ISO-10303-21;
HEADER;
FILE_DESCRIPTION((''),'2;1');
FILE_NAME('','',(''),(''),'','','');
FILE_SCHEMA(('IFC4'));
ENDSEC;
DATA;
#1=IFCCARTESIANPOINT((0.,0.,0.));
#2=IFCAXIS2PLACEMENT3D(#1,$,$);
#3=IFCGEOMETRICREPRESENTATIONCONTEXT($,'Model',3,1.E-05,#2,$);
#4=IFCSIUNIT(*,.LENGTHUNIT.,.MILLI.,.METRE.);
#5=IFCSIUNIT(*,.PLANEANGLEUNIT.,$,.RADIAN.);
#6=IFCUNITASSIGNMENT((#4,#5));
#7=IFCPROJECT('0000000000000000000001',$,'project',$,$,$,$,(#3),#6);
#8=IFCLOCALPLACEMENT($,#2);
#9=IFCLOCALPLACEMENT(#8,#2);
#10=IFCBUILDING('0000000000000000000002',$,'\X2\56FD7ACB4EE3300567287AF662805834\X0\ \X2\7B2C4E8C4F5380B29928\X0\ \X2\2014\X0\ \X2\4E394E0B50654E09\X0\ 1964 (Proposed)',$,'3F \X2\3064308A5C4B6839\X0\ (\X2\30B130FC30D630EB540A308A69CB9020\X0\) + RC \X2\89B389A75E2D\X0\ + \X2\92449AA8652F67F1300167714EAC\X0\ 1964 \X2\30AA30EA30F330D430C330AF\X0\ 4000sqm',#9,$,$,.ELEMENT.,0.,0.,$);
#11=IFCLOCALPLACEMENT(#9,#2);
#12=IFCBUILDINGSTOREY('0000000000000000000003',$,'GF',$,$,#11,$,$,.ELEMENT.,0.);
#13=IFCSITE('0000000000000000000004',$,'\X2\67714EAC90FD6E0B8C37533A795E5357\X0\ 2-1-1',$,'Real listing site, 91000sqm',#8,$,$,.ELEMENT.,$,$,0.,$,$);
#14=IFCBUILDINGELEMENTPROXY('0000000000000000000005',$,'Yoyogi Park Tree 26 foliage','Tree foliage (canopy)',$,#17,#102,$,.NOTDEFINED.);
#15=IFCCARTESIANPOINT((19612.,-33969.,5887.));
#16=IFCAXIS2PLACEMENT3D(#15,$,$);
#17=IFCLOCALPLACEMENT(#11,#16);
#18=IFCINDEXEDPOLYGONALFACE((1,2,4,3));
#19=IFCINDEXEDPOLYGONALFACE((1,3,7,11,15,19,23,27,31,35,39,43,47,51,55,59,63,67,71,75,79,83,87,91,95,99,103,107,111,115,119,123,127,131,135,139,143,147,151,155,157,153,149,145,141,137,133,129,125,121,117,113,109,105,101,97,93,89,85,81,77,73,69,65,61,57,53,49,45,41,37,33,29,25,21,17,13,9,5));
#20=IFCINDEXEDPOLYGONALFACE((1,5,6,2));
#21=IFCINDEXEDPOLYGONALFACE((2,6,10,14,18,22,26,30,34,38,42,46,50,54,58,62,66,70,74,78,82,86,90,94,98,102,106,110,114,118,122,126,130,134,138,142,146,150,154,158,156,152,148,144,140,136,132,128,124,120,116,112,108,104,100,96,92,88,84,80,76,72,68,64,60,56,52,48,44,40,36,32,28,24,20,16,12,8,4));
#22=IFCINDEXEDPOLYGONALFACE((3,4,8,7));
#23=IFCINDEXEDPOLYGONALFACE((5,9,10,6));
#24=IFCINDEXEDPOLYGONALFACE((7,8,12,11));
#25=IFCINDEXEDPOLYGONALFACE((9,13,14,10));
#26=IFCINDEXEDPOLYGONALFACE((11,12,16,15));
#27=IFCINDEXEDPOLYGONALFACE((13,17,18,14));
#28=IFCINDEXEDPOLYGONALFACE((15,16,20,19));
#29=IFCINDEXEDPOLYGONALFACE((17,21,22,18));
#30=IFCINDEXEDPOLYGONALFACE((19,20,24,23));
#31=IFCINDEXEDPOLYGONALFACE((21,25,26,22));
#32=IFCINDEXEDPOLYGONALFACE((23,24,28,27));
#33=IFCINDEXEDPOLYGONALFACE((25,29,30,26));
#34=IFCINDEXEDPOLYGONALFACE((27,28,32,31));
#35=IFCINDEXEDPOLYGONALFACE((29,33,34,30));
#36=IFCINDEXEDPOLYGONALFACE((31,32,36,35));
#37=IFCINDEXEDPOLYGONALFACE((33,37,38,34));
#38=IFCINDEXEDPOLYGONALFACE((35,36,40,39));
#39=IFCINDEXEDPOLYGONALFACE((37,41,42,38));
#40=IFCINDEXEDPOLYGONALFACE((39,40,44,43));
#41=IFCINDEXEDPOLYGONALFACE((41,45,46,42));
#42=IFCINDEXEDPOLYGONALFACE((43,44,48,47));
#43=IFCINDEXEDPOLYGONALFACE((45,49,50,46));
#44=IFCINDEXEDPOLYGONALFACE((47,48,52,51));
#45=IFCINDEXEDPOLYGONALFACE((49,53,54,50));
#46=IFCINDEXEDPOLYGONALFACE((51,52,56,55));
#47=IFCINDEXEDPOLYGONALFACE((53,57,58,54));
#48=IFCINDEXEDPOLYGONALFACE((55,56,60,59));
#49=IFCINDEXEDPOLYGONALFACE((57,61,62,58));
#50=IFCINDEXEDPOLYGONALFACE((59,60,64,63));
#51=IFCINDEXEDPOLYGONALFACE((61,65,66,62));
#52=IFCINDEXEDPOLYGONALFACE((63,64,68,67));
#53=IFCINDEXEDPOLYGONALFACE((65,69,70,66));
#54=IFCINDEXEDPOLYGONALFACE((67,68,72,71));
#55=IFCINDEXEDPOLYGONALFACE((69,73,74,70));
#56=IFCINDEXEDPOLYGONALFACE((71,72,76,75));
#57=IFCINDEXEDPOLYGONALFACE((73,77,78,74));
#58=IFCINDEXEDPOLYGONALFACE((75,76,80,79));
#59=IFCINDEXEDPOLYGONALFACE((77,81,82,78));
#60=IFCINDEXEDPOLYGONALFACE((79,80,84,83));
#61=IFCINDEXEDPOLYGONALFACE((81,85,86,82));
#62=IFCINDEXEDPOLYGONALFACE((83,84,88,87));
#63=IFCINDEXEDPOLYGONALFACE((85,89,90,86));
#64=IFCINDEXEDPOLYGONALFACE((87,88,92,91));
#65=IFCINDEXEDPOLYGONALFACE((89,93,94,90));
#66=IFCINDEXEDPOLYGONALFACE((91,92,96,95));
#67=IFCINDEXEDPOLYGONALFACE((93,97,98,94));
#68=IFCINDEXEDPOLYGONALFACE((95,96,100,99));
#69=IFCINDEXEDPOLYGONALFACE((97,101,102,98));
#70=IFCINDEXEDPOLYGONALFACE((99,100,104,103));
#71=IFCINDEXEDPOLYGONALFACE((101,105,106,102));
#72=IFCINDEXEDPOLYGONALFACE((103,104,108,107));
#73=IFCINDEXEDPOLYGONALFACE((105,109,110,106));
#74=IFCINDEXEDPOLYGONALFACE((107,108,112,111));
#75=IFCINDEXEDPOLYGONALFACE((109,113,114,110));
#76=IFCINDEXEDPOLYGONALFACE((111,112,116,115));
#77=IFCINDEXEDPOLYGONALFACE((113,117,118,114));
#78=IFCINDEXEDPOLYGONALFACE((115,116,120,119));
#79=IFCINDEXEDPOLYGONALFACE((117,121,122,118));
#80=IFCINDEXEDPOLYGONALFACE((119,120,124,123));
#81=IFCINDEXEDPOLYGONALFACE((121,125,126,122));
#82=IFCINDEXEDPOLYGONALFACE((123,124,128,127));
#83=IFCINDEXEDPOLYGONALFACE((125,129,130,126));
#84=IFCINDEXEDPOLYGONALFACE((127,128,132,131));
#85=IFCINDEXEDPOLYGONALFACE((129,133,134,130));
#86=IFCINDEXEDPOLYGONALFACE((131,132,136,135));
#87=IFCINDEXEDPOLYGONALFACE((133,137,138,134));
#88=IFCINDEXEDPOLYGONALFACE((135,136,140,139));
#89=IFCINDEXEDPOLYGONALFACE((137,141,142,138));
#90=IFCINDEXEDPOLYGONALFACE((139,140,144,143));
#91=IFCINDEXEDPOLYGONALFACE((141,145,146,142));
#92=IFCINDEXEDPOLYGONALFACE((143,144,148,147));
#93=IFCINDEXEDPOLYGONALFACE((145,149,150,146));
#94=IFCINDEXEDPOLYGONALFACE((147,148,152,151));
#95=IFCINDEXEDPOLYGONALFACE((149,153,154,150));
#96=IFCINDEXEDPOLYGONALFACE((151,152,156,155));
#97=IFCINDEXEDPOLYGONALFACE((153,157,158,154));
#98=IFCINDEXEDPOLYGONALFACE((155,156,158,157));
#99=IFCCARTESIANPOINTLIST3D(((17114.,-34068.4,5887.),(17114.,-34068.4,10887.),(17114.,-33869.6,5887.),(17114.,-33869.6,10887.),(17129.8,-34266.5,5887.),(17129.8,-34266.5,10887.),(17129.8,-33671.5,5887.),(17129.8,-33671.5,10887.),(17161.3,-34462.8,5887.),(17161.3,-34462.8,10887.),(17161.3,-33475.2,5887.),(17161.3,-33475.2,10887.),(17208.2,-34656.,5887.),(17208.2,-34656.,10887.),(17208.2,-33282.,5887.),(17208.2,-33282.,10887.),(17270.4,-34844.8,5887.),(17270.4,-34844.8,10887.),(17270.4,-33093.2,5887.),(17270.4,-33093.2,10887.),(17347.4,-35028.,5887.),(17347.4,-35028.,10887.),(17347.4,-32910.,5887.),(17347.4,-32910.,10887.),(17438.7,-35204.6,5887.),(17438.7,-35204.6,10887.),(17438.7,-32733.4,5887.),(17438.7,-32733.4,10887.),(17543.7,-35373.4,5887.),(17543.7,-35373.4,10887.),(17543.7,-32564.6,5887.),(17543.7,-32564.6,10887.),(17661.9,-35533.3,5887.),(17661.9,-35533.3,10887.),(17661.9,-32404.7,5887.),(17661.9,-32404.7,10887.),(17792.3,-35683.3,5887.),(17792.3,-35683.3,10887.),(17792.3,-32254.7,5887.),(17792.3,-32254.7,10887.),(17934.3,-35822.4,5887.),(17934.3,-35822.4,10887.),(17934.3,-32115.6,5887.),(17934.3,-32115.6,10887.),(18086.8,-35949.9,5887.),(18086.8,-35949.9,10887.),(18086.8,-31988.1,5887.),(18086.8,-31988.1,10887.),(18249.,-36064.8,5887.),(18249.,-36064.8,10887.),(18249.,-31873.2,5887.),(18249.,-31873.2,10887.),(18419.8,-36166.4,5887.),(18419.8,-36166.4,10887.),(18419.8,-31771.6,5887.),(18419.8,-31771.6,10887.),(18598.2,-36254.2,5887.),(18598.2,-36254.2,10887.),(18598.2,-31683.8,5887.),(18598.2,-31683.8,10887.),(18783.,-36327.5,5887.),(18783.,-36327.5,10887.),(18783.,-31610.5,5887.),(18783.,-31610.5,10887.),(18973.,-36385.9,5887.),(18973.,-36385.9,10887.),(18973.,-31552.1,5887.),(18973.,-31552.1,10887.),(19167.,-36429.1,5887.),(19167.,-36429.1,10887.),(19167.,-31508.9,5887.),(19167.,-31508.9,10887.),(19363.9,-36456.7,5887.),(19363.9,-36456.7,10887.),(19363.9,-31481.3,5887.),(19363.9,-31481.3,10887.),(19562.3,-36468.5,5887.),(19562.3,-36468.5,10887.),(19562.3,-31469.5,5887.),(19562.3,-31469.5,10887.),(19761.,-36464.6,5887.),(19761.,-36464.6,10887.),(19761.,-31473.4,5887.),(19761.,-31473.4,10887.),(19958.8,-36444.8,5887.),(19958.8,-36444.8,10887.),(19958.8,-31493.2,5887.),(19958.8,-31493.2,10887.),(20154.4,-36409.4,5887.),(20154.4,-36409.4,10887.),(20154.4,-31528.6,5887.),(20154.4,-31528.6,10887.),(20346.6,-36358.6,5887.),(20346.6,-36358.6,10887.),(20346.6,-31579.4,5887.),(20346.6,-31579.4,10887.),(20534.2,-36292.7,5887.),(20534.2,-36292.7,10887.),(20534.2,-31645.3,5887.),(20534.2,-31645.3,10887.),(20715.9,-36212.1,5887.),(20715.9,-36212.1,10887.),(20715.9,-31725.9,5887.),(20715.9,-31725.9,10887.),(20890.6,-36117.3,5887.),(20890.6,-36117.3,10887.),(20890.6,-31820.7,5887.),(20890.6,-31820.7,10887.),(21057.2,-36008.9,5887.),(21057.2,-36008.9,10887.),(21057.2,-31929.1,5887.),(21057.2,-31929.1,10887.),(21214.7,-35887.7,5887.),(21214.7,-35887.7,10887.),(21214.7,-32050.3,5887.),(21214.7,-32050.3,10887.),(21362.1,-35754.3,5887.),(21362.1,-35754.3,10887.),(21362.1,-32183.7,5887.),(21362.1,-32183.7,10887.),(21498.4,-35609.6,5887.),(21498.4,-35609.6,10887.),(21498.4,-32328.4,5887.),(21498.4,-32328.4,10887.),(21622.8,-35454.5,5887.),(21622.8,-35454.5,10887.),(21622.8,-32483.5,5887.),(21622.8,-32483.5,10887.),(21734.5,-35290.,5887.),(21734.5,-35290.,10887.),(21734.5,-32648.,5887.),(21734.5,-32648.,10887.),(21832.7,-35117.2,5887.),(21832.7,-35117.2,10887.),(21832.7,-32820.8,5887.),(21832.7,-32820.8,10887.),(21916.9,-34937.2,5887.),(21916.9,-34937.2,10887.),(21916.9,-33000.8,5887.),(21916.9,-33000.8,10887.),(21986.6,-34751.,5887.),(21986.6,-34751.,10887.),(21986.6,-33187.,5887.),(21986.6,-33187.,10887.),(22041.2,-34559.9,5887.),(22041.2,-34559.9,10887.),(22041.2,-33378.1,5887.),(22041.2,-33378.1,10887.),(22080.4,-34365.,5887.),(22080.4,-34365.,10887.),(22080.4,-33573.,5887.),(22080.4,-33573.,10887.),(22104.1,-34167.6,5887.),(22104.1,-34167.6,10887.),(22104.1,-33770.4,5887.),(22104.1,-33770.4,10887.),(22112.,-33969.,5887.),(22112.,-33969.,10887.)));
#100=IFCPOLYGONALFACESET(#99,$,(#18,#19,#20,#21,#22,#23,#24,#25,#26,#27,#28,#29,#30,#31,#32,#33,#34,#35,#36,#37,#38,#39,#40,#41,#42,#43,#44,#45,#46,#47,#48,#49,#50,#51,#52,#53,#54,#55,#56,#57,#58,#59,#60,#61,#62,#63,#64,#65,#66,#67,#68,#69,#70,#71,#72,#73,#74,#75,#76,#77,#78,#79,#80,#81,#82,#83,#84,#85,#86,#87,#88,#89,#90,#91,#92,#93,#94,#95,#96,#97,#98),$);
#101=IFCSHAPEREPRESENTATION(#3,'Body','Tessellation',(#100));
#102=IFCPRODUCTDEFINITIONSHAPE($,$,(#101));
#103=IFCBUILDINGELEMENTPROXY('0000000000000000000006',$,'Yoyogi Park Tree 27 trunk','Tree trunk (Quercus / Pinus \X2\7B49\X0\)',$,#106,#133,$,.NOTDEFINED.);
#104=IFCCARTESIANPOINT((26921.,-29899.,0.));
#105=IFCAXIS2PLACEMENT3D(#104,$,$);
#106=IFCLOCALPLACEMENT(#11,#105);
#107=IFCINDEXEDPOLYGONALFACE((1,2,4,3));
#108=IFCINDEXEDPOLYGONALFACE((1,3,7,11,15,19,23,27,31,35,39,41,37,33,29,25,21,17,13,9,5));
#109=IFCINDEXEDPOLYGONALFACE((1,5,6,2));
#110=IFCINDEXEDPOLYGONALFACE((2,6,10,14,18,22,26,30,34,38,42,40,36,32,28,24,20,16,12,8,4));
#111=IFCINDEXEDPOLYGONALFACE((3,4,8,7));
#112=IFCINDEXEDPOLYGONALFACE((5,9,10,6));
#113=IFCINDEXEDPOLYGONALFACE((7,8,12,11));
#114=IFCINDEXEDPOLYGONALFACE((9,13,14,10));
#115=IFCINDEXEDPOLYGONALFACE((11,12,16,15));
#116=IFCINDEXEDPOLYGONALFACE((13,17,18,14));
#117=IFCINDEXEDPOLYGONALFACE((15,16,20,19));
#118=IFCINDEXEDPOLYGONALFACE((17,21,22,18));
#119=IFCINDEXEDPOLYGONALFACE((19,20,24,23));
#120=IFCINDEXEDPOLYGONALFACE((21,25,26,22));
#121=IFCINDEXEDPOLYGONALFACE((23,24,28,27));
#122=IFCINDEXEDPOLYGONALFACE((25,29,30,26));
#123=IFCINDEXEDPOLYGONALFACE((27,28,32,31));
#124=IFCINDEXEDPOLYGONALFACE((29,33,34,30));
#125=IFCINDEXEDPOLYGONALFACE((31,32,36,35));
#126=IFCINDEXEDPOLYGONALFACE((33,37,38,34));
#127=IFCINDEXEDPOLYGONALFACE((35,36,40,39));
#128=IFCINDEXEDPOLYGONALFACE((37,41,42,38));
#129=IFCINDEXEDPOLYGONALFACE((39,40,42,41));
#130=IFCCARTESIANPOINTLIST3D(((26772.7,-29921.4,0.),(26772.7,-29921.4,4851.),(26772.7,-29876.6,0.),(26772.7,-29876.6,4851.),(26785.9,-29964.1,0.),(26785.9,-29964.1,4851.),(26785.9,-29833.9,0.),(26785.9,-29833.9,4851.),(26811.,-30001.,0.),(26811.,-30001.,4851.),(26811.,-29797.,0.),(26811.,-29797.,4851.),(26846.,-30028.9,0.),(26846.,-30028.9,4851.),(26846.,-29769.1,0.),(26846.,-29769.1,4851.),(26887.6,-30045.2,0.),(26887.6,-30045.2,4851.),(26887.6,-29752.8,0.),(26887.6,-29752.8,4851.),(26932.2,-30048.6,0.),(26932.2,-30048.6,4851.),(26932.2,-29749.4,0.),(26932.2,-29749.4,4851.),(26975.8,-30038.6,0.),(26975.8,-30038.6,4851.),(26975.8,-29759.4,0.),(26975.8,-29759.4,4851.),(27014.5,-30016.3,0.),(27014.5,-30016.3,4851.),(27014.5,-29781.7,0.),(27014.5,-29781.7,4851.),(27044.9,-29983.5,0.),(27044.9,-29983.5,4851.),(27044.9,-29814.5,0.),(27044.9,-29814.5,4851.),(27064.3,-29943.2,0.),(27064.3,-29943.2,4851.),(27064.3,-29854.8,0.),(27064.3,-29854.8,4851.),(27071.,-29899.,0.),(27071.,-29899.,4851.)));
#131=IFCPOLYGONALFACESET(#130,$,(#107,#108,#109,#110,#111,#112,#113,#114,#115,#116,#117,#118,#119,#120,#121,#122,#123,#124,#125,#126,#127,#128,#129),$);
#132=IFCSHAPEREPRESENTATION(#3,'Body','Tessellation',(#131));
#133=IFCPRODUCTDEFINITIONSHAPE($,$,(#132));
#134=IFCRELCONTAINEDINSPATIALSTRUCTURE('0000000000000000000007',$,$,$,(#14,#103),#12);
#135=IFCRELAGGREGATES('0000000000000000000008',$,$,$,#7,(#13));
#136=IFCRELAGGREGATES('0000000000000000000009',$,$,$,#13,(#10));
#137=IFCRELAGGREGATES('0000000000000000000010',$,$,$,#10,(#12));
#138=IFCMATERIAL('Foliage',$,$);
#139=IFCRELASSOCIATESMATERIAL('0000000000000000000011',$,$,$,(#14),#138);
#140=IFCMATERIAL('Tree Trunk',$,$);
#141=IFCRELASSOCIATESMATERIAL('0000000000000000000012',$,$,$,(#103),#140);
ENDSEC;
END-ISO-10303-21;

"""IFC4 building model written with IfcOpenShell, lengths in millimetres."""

from ifc_helpers import new_model, si_unit, frame, origin, origin_2d, place, context, project, spatial, circle, extrude, material, element, save


model = new_model("IFC4")

# Units and contexts
model_context = context("Model", 3, precision=1e-05, world=origin())
ifc_project = project(units=[si_unit("LENGTHUNIT", "METRE", prefix="MILLI"), si_unit("PLANEANGLEUNIT", "RADIAN")], contexts=[model_context])

# Site, building, storey
site_placement = place(None, origin())
site = spatial("IfcSite", under=ifc_project, at=site_placement, Name="東京都渋谷区神南 2-1-1", ObjectType="Real listing site, 91000sqm", CompositionType="ELEMENT", RefElevation=0.0)
building_placement = place(site_placement, origin())
building = spatial("IfcBuilding", under=site, at=building_placement, Name="国立代々木競技場 第二体育館 — 丹下健三 1964 (Proposed)", ObjectType="3F つり屋根 (ケーブル吊り構造) + RC 観覧席 + 鉄骨支柱、東京 1964 オリンピック 4000sqm", CompositionType="ELEMENT", ElevationOfRefHeight=0.0, ElevationOfTerrain=0.0)
storey_placement = place(building_placement, origin())
storey = spatial("IfcBuildingStorey", under=building, at=storey_placement, Name="GF", CompositionType="ELEMENT", Elevation=0.0)

# Building element proxies
ifc_material_1 = material(Name="Tree Trunk")
ifc_material_2 = material(Name="Foliage")
proxy_1_placement = place(storey_placement, frame((19612.0, -33969.0, 5887.0)))
element("IfcBuildingElementProxy", 1, at=proxy_1_placement, inside=storey, material=ifc_material_2, Name="Yoyogi Park Tree 26 foliage", Description="Tree foliage (canopy)", PredefinedType="NOTDEFINED", context=model_context, shape_type="SweptSolid", body=[
    extrude(circle(Radius=2500.0, at=origin_2d()), frame((19612.0, -33969.0, 5887.0)), (0.0, 0.0, 1.0), 5000.0),
])
proxy_2_placement = place(storey_placement, frame((26921.0, -29899.0, 0.0)))
element("IfcBuildingElementProxy", 2, at=proxy_2_placement, inside=storey, material=ifc_material_1, Name="Yoyogi Park Tree 27 trunk", Description="Tree trunk (Quercus / Pinus 等)", PredefinedType="NOTDEFINED", context=model_context, shape_type="SweptSolid", body=[
    extrude(circle(Radius=150.0, at=origin_2d()), frame((26921.0, -29899.0, 0.0)), (0.0, 0.0, 1.0), 4851.0),
])

save(model, "model.ifc")
